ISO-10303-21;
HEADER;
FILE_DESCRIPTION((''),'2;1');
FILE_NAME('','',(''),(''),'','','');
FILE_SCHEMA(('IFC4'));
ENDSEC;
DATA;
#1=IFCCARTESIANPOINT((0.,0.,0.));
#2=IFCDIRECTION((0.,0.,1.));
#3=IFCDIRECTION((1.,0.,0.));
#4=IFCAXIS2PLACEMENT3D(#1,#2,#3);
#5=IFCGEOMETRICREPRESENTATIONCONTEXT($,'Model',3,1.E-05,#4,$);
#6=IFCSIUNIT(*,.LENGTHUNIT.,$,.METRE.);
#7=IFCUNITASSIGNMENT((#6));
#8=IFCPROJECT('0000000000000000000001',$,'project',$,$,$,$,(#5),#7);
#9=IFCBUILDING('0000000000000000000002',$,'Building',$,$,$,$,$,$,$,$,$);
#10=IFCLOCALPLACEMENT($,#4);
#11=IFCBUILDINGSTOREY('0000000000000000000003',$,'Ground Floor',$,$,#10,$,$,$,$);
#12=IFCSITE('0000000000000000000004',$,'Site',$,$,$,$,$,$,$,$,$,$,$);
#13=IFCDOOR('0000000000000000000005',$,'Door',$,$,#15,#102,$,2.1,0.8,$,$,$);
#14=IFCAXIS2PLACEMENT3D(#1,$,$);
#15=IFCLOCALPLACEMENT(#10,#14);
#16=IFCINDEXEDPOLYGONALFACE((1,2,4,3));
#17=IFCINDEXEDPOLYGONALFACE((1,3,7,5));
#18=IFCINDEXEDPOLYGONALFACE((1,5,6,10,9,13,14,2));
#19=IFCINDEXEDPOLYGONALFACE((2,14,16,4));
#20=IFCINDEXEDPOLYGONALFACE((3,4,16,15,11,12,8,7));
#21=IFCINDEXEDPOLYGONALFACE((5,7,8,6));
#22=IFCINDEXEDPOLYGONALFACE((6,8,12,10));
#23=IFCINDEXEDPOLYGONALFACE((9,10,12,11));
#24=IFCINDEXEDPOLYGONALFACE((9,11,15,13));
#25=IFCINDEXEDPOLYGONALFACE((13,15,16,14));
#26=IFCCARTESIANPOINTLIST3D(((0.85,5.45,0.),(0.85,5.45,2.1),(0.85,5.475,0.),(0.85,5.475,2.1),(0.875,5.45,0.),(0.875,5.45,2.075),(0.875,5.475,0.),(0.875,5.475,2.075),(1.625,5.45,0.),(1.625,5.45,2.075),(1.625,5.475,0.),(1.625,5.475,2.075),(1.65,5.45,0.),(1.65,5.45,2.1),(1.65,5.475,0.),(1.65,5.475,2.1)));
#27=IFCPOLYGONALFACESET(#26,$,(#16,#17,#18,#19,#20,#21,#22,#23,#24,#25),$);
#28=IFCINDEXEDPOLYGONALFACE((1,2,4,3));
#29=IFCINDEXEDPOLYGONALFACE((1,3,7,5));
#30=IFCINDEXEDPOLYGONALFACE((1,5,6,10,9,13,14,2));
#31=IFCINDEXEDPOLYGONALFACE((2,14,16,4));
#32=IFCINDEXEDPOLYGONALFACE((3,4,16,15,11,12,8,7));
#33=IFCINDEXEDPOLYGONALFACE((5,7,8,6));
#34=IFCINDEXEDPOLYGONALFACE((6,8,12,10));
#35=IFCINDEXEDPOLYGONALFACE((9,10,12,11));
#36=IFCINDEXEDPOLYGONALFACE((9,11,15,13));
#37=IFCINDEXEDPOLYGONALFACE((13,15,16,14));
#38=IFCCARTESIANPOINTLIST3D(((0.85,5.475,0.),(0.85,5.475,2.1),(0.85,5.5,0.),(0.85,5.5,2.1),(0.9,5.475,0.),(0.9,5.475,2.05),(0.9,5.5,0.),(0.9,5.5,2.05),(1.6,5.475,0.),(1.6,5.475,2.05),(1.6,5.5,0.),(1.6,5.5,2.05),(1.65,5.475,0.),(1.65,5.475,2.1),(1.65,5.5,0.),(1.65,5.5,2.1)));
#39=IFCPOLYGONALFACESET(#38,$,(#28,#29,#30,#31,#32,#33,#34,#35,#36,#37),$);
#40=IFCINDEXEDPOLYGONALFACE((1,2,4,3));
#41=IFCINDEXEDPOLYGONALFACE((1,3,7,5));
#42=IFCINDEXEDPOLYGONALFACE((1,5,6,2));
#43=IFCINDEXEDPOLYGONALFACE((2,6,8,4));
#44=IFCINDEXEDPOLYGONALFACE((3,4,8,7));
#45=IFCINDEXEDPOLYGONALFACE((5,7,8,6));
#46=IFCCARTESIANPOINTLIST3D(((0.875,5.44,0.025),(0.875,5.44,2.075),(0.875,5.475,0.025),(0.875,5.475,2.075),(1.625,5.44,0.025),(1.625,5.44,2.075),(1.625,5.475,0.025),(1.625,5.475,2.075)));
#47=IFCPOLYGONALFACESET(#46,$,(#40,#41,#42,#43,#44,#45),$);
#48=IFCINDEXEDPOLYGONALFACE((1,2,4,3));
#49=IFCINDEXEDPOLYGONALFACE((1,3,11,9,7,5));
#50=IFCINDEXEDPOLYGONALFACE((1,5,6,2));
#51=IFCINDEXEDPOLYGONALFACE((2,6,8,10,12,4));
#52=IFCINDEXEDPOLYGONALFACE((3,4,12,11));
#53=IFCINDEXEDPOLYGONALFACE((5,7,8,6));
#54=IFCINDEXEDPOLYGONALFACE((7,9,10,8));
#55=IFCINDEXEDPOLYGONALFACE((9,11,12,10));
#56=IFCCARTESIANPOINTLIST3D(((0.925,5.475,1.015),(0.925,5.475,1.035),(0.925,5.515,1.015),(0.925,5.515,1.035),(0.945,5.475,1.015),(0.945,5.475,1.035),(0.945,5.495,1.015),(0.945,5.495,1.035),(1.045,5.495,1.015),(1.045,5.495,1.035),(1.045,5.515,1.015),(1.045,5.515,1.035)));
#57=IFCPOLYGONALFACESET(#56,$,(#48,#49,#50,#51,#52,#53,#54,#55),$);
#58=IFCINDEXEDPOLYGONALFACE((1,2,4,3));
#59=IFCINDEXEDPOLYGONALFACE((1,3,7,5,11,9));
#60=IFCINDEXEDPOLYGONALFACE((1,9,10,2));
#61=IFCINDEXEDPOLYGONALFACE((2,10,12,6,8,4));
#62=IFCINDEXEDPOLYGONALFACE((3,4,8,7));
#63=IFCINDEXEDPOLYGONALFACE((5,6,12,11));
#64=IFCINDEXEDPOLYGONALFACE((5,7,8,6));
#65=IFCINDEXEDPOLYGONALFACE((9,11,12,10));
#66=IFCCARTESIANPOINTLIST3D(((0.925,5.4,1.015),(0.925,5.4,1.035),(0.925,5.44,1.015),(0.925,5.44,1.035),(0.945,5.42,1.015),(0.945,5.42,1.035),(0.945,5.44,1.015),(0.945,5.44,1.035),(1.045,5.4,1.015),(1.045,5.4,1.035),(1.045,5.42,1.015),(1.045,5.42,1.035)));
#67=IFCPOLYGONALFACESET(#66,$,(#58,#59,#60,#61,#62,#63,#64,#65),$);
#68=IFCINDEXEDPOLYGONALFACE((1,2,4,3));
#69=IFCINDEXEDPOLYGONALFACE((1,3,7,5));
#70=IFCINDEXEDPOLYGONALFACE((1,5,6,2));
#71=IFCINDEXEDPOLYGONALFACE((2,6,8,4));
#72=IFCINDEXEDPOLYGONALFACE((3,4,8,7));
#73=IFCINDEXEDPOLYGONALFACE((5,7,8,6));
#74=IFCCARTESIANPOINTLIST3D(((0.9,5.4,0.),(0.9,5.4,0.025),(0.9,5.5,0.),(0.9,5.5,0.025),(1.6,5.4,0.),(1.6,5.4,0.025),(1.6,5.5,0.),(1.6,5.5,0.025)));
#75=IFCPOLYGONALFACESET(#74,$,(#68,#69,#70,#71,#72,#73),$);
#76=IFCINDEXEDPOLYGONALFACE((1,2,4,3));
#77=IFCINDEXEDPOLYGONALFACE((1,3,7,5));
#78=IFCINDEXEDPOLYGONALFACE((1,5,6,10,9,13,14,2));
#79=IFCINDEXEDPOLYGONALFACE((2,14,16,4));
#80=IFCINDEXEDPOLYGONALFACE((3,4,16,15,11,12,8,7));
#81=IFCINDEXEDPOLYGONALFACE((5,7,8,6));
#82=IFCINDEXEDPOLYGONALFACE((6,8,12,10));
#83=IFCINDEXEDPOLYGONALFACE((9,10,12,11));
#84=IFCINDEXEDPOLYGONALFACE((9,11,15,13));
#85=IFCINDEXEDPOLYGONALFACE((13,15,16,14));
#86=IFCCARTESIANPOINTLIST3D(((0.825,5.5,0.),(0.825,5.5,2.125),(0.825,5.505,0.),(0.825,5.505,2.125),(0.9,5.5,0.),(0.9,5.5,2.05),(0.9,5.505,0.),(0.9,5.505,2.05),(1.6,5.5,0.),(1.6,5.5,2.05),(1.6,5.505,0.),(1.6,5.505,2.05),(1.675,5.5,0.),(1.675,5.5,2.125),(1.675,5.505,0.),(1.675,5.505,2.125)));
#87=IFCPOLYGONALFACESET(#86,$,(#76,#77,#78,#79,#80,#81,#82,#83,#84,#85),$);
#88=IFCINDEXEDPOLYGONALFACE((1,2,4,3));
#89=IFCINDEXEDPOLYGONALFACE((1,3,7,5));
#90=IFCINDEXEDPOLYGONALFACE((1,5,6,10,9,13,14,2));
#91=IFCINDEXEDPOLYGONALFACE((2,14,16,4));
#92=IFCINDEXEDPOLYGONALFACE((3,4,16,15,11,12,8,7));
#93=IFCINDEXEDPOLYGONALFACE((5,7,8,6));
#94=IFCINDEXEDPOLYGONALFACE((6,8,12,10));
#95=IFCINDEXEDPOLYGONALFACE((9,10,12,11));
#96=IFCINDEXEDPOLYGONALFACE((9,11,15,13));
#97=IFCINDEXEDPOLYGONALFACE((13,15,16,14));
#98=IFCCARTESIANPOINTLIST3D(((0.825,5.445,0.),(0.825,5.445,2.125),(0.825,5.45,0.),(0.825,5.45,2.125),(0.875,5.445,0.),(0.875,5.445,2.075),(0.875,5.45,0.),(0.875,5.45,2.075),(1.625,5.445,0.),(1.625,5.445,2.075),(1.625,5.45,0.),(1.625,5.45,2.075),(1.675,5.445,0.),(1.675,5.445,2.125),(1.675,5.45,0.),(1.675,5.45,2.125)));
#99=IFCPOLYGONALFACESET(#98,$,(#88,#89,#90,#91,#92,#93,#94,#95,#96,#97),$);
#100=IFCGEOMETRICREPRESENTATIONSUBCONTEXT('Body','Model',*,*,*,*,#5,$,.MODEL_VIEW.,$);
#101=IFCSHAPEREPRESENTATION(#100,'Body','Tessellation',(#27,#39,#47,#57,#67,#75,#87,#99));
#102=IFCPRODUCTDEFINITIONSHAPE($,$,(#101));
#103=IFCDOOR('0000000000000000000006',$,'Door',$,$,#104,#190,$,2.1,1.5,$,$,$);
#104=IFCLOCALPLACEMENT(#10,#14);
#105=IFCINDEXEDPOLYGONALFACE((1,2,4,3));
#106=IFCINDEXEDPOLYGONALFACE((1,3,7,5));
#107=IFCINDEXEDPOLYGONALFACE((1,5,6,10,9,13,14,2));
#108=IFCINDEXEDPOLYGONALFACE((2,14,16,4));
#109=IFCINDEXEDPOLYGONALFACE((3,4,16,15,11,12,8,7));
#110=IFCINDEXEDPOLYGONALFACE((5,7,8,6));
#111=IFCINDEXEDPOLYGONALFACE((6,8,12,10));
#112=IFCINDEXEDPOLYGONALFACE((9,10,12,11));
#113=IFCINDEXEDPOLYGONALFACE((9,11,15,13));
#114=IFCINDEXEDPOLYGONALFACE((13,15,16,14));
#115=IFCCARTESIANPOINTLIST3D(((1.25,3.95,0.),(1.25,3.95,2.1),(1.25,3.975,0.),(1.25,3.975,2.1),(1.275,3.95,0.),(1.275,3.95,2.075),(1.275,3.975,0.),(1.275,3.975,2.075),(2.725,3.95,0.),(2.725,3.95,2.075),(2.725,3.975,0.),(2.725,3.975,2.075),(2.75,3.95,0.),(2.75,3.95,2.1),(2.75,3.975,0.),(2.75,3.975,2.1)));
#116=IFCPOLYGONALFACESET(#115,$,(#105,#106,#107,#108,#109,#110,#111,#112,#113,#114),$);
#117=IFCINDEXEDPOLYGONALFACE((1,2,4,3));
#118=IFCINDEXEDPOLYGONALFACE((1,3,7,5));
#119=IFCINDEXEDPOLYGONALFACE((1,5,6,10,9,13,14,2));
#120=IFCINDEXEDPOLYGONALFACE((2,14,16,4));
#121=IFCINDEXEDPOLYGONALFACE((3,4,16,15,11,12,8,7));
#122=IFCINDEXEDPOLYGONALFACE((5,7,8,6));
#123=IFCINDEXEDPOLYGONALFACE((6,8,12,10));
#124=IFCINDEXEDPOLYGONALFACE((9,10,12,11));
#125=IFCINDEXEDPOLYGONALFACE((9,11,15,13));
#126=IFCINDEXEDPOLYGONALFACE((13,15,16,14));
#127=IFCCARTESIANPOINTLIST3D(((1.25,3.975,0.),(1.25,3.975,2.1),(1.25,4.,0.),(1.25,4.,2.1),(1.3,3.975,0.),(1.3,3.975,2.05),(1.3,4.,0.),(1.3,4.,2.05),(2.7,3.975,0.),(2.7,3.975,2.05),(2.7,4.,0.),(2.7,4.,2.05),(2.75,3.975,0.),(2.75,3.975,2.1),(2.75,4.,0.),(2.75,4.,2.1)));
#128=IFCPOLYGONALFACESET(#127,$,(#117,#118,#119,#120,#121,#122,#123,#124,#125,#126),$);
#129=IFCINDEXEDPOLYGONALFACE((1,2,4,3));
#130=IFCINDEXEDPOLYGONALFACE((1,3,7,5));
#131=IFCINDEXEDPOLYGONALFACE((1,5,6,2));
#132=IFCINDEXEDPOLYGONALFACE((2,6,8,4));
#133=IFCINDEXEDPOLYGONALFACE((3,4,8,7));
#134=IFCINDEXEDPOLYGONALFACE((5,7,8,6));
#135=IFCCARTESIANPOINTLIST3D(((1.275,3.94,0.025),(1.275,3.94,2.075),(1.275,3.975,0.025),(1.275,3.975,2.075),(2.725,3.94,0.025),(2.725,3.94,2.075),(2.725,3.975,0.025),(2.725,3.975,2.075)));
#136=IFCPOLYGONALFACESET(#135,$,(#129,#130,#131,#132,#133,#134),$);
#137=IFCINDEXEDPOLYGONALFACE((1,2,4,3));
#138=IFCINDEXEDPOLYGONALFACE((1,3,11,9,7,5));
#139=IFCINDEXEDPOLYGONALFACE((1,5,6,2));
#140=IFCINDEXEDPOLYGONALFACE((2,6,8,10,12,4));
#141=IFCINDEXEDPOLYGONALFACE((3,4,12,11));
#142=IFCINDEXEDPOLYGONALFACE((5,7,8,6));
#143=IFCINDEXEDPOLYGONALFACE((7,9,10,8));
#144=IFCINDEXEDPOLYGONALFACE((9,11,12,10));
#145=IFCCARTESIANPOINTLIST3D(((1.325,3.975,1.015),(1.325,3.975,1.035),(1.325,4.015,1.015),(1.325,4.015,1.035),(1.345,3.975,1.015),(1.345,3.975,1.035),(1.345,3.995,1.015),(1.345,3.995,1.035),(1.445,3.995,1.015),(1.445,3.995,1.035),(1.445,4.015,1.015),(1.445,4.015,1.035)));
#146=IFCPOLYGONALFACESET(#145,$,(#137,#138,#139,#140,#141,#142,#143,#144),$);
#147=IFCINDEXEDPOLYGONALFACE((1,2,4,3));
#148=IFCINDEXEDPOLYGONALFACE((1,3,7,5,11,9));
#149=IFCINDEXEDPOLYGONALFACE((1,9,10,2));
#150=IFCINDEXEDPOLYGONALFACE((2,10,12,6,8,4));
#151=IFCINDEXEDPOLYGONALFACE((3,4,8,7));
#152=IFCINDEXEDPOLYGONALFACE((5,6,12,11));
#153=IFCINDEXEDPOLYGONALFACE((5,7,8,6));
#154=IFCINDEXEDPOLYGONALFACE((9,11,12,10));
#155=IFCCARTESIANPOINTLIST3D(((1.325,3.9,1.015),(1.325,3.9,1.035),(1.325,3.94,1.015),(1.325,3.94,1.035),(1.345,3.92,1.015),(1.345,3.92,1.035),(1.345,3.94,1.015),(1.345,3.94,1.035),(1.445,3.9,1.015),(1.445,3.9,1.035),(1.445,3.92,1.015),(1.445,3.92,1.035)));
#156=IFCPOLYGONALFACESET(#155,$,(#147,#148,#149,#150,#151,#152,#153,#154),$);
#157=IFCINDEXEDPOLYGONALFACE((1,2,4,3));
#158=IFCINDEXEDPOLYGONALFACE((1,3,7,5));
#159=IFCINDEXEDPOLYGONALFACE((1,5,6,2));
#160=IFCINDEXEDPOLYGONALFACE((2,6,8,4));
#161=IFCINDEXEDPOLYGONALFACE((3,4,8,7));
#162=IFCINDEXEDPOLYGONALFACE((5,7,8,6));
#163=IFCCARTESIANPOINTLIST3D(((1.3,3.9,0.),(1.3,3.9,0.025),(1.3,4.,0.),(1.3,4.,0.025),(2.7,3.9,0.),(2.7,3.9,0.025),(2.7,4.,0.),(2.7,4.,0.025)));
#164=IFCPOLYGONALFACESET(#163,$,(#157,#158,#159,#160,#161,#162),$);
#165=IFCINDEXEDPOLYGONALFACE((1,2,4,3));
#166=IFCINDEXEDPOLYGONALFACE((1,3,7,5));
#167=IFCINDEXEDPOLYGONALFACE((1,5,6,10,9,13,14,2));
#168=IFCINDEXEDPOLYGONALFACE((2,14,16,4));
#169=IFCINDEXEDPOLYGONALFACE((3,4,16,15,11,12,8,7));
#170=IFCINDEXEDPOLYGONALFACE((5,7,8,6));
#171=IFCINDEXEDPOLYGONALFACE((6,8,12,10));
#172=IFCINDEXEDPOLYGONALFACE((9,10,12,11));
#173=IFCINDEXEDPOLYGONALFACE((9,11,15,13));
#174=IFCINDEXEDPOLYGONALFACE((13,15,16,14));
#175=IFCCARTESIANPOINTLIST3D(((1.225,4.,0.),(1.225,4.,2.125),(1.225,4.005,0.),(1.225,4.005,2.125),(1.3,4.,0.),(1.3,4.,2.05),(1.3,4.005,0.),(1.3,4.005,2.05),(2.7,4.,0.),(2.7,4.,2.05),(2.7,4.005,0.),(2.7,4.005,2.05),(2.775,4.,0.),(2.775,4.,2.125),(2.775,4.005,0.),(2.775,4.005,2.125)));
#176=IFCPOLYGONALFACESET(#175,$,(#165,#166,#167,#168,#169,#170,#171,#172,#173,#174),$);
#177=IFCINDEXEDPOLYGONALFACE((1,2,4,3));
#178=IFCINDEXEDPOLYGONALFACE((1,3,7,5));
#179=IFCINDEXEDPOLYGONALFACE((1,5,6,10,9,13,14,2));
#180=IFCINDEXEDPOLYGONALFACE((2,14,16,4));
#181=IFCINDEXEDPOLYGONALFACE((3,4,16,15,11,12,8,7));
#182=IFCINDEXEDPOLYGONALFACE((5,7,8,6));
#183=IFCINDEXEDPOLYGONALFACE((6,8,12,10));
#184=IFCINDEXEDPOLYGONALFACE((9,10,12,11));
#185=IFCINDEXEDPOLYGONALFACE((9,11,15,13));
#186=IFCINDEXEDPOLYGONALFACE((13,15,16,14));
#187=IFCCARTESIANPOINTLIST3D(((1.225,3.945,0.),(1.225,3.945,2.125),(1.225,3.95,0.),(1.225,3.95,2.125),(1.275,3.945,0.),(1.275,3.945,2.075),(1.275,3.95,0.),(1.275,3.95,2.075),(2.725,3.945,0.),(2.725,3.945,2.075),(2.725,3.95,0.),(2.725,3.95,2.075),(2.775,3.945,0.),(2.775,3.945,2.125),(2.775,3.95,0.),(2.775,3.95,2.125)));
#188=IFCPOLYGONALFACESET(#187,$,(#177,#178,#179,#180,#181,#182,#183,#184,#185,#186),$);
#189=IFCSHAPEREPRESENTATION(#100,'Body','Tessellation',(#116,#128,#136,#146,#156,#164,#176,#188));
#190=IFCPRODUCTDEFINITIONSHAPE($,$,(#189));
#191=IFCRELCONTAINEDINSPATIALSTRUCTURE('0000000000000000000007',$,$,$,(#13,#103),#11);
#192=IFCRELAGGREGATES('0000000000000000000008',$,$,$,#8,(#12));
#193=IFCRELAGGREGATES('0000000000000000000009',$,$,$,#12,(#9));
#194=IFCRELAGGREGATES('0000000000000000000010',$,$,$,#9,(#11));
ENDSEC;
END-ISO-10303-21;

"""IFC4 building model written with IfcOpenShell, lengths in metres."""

from ifc_helpers import new_model, si_unit, frame, origin_with_axes, place, context, subcontext, project, spatial, line, indexed_curve, outline, extrude, element, save


model = new_model("IFC4")

# Units and contexts
model_context = context("Model", 3, precision=1e-05, world=origin_with_axes())
body_context = subcontext(model_context, "Body", "Model", "MODEL_VIEW")
ifc_project = project(units=[si_unit("LENGTHUNIT", "METRE")], contexts=[model_context])

# Site, building, storey
site = spatial("IfcSite", under=ifc_project, Name="Site")
building = spatial("IfcBuilding", under=site, Name="Building")
storey_placement = place(None, origin_with_axes())
storey = spatial("IfcBuildingStorey", under=building, at=storey_placement, Name="Ground Floor")

# Doors
door_1_placement = place(storey_placement, frame((1.65, 5.5, 0.0), z_axis=(0.0, 0.0, 1.0), x_axis=(-1.0, 0.0, 0.0)))
element("IfcDoor", 1, at=door_1_placement, inside=storey, Name="Door", OverallHeight=2.1, OverallWidth=0.8, context=body_context, shape_type="SweptSolid", body=[
    extrude(outline(indexed_curve([(0.0, 0.0), (0.0, 2.1), (0.8, 2.1), (0.8, 0.0), (0.775, 0.0), (0.775, 2.075), (0.025, 2.075), (0.025, 0.0)], segments=[line(1, 2, 3, 4, 5, 6, 7, 8, 1)])), frame((0.0, 0.025, 0.0), z_axis=(0.0, -1.0, 0.0), x_axis=(1.0, 0.0, 0.0)), (0.0, 0.0, -1.0), 0.025),
    extrude(outline(indexed_curve([(0.0, 0.0), (0.0, 2.1), (0.8, 2.1), (0.8, 0.0), (0.75, 0.0), (0.75, 2.05), (0.05, 2.05), (0.05, 0.0)], segments=[line(1, 2, 3, 4, 5, 6, 7, 8, 1)])), frame((0.0, 0.0, 0.0), z_axis=(0.0, -1.0, 0.0), x_axis=(1.0, 0.0, 0.0)), (0.0, 0.0, -1.0), 0.025),
    extrude(outline(indexed_curve([(0.0, 0.0), (0.75, 0.0), (0.75, 0.035), (0.0, 0.035)], segments=[line(1, 2, 3, 4, 1)])), frame((0.025, 0.025, 0.025), z_axis=(0.0, 0.0, 1.0), x_axis=(1.0, 0.0, 0.0)), (0.0, 0.0, 1.0), 2.05),
    extrude(outline(indexed_curve([(0.0, 0.0), (0.0, -0.04), (-0.12, -0.04), (-0.12, -0.02), (-0.02, -0.02), (-0.02, 0.0)], segments=[line(1, 2, 3, 4, 5, 6, 1)])), frame((0.725, 0.025, 1.015), z_axis=(0.0, 0.0, 1.0), x_axis=(1.0, 0.0, 0.0)), (0.0, 0.0, 1.0), 0.02),
    extrude(outline(indexed_curve([(0.0, 0.0), (0.0, 0.04), (-0.12, 0.04), (-0.12, 0.02), (-0.02, 0.02), (-0.02, 0.0)], segments=[line(1, 2, 3, 4, 5, 6, 1)])), frame((0.725, 0.06, 1.015), z_axis=(0.0, 0.0, 1.0), x_axis=(1.0, 0.0, 0.0)), (0.0, 0.0, 1.0), 0.02),
    extrude(outline(indexed_curve([(0.0, 0.0), (0.7, 0.0), (0.7, 0.1), (0.0, 0.1)], segments=[line(1, 2, 3, 4, 1)])), frame((0.05, 0.0, 0.0), z_axis=(0.0, 0.0, 1.0), x_axis=(1.0, 0.0, 0.0)), (0.0, 0.0, 1.0), 0.025),
    extrude(outline(indexed_curve([(0.0, 0.0), (0.0, 2.125), (0.85, 2.125), (0.85, 0.0), (0.775, 0.0), (0.775, 2.05), (0.075, 2.05), (0.075, 0.0)], segments=[line(1, 2, 3, 4, 5, 6, 7, 8, 1)])), frame((-0.025, -0.005, 0.0), z_axis=(0.0, -1.0, 0.0), x_axis=(1.0, 0.0, 0.0)), (0.0, 0.0, -1.0), 0.005),
    extrude(outline(indexed_curve([(0.0, 0.0), (0.0, 2.125), (0.85, 2.125), (0.85, 0.0), (0.8, 0.0), (0.8, 2.075), (0.05, 2.075), (0.05, 0.0)], segments=[line(1, 2, 3, 4, 5, 6, 7, 8, 1)])), frame((-0.025, 0.05, 0.0), z_axis=(0.0, -1.0, 0.0), x_axis=(1.0, 0.0, 0.0)), (0.0, 0.0, -1.0), 0.005),
])
door_2_placement = place(storey_placement, frame((2.75, 4.0, 0.0), z_axis=(0.0, 0.0, 1.0), x_axis=(-1.0, 0.0, 0.0)))
element("IfcDoor", 2, at=door_2_placement, inside=storey, Name="Door", OverallHeight=2.1, OverallWidth=1.5, context=body_context, shape_type="SweptSolid", body=[
    extrude(outline(indexed_curve([(0.0, 0.0), (0.0, 2.1), (1.5, 2.1), (1.5, 0.0), (1.475, 0.0), (1.475, 2.075), (0.025, 2.075), (0.025, 0.0)], segments=[line(1, 2, 3, 4, 5, 6, 7, 8, 1)])), frame((0.0, 0.025, 0.0), z_axis=(0.0, -1.0, 0.0), x_axis=(1.0, 0.0, 0.0)), (0.0, 0.0, -1.0), 0.025),
    extrude(outline(indexed_curve([(0.0, 0.0), (0.0, 2.1), (1.5, 2.1), (1.5, 0.0), (1.45, 0.0), (1.45, 2.05), (0.05, 2.05), (0.05, 0.0)], segments=[line(1, 2, 3, 4, 5, 6, 7, 8, 1)])), frame((0.0, 0.0, 0.0), z_axis=(0.0, -1.0, 0.0), x_axis=(1.0, 0.0, 0.0)), (0.0, 0.0, -1.0), 0.025),
    extrude(outline(indexed_curve([(0.0, 0.0), (1.45, 0.0), (1.45, 0.035), (0.0, 0.035)], segments=[line(1, 2, 3, 4, 1)])), frame((0.025, 0.025, 0.025), z_axis=(0.0, 0.0, 1.0), x_axis=(1.0, 0.0, 0.0)), (0.0, 0.0, 1.0), 2.05),
    extrude(outline(indexed_curve([(0.0, 0.0), (0.0, -0.04), (-0.12, -0.04), (-0.12, -0.02), (-0.02, -0.02), (-0.02, 0.0)], segments=[line(1, 2, 3, 4, 5, 6, 1)])), frame((1.425, 0.025, 1.015), z_axis=(0.0, 0.0, 1.0), x_axis=(1.0, 0.0, 0.0)), (0.0, 0.0, 1.0), 0.02),
    extrude(outline(indexed_curve([(0.0, 0.0), (0.0, 0.04), (-0.12, 0.04), (-0.12, 0.02), (-0.02, 0.02), (-0.02, 0.0)], segments=[line(1, 2, 3, 4, 5, 6, 1)])), frame((1.425, 0.06, 1.015), z_axis=(0.0, 0.0, 1.0), x_axis=(1.0, 0.0, 0.0)), (0.0, 0.0, 1.0), 0.02),
    extrude(outline(indexed_curve([(0.0, 0.0), (1.4, 0.0), (1.4, 0.1), (0.0, 0.1)], segments=[line(1, 2, 3, 4, 1)])), frame((0.05, 0.0, 0.0), z_axis=(0.0, 0.0, 1.0), x_axis=(1.0, 0.0, 0.0)), (0.0, 0.0, 1.0), 0.025),
    extrude(outline(indexed_curve([(0.0, 0.0), (0.0, 2.125), (1.55, 2.125), (1.55, 0.0), (1.475, 0.0), (1.475, 2.05), (0.075, 2.05), (0.075, 0.0)], segments=[line(1, 2, 3, 4, 5, 6, 7, 8, 1)])), frame((-0.025, -0.005, 0.0), z_axis=(0.0, -1.0, 0.0), x_axis=(1.0, 0.0, 0.0)), (0.0, 0.0, -1.0), 0.005),
    extrude(outline(indexed_curve([(0.0, 0.0), (0.0, 2.125), (1.55, 2.125), (1.55, 0.0), (1.5, 0.0), (1.5, 2.075), (0.05, 2.075), (0.05, 0.0)], segments=[line(1, 2, 3, 4, 5, 6, 7, 8, 1)])), frame((-0.025, 0.05, 0.0), z_axis=(0.0, -1.0, 0.0), x_axis=(1.0, 0.0, 0.0)), (0.0, 0.0, -1.0), 0.005),
])

save(model, "model.ifc")
